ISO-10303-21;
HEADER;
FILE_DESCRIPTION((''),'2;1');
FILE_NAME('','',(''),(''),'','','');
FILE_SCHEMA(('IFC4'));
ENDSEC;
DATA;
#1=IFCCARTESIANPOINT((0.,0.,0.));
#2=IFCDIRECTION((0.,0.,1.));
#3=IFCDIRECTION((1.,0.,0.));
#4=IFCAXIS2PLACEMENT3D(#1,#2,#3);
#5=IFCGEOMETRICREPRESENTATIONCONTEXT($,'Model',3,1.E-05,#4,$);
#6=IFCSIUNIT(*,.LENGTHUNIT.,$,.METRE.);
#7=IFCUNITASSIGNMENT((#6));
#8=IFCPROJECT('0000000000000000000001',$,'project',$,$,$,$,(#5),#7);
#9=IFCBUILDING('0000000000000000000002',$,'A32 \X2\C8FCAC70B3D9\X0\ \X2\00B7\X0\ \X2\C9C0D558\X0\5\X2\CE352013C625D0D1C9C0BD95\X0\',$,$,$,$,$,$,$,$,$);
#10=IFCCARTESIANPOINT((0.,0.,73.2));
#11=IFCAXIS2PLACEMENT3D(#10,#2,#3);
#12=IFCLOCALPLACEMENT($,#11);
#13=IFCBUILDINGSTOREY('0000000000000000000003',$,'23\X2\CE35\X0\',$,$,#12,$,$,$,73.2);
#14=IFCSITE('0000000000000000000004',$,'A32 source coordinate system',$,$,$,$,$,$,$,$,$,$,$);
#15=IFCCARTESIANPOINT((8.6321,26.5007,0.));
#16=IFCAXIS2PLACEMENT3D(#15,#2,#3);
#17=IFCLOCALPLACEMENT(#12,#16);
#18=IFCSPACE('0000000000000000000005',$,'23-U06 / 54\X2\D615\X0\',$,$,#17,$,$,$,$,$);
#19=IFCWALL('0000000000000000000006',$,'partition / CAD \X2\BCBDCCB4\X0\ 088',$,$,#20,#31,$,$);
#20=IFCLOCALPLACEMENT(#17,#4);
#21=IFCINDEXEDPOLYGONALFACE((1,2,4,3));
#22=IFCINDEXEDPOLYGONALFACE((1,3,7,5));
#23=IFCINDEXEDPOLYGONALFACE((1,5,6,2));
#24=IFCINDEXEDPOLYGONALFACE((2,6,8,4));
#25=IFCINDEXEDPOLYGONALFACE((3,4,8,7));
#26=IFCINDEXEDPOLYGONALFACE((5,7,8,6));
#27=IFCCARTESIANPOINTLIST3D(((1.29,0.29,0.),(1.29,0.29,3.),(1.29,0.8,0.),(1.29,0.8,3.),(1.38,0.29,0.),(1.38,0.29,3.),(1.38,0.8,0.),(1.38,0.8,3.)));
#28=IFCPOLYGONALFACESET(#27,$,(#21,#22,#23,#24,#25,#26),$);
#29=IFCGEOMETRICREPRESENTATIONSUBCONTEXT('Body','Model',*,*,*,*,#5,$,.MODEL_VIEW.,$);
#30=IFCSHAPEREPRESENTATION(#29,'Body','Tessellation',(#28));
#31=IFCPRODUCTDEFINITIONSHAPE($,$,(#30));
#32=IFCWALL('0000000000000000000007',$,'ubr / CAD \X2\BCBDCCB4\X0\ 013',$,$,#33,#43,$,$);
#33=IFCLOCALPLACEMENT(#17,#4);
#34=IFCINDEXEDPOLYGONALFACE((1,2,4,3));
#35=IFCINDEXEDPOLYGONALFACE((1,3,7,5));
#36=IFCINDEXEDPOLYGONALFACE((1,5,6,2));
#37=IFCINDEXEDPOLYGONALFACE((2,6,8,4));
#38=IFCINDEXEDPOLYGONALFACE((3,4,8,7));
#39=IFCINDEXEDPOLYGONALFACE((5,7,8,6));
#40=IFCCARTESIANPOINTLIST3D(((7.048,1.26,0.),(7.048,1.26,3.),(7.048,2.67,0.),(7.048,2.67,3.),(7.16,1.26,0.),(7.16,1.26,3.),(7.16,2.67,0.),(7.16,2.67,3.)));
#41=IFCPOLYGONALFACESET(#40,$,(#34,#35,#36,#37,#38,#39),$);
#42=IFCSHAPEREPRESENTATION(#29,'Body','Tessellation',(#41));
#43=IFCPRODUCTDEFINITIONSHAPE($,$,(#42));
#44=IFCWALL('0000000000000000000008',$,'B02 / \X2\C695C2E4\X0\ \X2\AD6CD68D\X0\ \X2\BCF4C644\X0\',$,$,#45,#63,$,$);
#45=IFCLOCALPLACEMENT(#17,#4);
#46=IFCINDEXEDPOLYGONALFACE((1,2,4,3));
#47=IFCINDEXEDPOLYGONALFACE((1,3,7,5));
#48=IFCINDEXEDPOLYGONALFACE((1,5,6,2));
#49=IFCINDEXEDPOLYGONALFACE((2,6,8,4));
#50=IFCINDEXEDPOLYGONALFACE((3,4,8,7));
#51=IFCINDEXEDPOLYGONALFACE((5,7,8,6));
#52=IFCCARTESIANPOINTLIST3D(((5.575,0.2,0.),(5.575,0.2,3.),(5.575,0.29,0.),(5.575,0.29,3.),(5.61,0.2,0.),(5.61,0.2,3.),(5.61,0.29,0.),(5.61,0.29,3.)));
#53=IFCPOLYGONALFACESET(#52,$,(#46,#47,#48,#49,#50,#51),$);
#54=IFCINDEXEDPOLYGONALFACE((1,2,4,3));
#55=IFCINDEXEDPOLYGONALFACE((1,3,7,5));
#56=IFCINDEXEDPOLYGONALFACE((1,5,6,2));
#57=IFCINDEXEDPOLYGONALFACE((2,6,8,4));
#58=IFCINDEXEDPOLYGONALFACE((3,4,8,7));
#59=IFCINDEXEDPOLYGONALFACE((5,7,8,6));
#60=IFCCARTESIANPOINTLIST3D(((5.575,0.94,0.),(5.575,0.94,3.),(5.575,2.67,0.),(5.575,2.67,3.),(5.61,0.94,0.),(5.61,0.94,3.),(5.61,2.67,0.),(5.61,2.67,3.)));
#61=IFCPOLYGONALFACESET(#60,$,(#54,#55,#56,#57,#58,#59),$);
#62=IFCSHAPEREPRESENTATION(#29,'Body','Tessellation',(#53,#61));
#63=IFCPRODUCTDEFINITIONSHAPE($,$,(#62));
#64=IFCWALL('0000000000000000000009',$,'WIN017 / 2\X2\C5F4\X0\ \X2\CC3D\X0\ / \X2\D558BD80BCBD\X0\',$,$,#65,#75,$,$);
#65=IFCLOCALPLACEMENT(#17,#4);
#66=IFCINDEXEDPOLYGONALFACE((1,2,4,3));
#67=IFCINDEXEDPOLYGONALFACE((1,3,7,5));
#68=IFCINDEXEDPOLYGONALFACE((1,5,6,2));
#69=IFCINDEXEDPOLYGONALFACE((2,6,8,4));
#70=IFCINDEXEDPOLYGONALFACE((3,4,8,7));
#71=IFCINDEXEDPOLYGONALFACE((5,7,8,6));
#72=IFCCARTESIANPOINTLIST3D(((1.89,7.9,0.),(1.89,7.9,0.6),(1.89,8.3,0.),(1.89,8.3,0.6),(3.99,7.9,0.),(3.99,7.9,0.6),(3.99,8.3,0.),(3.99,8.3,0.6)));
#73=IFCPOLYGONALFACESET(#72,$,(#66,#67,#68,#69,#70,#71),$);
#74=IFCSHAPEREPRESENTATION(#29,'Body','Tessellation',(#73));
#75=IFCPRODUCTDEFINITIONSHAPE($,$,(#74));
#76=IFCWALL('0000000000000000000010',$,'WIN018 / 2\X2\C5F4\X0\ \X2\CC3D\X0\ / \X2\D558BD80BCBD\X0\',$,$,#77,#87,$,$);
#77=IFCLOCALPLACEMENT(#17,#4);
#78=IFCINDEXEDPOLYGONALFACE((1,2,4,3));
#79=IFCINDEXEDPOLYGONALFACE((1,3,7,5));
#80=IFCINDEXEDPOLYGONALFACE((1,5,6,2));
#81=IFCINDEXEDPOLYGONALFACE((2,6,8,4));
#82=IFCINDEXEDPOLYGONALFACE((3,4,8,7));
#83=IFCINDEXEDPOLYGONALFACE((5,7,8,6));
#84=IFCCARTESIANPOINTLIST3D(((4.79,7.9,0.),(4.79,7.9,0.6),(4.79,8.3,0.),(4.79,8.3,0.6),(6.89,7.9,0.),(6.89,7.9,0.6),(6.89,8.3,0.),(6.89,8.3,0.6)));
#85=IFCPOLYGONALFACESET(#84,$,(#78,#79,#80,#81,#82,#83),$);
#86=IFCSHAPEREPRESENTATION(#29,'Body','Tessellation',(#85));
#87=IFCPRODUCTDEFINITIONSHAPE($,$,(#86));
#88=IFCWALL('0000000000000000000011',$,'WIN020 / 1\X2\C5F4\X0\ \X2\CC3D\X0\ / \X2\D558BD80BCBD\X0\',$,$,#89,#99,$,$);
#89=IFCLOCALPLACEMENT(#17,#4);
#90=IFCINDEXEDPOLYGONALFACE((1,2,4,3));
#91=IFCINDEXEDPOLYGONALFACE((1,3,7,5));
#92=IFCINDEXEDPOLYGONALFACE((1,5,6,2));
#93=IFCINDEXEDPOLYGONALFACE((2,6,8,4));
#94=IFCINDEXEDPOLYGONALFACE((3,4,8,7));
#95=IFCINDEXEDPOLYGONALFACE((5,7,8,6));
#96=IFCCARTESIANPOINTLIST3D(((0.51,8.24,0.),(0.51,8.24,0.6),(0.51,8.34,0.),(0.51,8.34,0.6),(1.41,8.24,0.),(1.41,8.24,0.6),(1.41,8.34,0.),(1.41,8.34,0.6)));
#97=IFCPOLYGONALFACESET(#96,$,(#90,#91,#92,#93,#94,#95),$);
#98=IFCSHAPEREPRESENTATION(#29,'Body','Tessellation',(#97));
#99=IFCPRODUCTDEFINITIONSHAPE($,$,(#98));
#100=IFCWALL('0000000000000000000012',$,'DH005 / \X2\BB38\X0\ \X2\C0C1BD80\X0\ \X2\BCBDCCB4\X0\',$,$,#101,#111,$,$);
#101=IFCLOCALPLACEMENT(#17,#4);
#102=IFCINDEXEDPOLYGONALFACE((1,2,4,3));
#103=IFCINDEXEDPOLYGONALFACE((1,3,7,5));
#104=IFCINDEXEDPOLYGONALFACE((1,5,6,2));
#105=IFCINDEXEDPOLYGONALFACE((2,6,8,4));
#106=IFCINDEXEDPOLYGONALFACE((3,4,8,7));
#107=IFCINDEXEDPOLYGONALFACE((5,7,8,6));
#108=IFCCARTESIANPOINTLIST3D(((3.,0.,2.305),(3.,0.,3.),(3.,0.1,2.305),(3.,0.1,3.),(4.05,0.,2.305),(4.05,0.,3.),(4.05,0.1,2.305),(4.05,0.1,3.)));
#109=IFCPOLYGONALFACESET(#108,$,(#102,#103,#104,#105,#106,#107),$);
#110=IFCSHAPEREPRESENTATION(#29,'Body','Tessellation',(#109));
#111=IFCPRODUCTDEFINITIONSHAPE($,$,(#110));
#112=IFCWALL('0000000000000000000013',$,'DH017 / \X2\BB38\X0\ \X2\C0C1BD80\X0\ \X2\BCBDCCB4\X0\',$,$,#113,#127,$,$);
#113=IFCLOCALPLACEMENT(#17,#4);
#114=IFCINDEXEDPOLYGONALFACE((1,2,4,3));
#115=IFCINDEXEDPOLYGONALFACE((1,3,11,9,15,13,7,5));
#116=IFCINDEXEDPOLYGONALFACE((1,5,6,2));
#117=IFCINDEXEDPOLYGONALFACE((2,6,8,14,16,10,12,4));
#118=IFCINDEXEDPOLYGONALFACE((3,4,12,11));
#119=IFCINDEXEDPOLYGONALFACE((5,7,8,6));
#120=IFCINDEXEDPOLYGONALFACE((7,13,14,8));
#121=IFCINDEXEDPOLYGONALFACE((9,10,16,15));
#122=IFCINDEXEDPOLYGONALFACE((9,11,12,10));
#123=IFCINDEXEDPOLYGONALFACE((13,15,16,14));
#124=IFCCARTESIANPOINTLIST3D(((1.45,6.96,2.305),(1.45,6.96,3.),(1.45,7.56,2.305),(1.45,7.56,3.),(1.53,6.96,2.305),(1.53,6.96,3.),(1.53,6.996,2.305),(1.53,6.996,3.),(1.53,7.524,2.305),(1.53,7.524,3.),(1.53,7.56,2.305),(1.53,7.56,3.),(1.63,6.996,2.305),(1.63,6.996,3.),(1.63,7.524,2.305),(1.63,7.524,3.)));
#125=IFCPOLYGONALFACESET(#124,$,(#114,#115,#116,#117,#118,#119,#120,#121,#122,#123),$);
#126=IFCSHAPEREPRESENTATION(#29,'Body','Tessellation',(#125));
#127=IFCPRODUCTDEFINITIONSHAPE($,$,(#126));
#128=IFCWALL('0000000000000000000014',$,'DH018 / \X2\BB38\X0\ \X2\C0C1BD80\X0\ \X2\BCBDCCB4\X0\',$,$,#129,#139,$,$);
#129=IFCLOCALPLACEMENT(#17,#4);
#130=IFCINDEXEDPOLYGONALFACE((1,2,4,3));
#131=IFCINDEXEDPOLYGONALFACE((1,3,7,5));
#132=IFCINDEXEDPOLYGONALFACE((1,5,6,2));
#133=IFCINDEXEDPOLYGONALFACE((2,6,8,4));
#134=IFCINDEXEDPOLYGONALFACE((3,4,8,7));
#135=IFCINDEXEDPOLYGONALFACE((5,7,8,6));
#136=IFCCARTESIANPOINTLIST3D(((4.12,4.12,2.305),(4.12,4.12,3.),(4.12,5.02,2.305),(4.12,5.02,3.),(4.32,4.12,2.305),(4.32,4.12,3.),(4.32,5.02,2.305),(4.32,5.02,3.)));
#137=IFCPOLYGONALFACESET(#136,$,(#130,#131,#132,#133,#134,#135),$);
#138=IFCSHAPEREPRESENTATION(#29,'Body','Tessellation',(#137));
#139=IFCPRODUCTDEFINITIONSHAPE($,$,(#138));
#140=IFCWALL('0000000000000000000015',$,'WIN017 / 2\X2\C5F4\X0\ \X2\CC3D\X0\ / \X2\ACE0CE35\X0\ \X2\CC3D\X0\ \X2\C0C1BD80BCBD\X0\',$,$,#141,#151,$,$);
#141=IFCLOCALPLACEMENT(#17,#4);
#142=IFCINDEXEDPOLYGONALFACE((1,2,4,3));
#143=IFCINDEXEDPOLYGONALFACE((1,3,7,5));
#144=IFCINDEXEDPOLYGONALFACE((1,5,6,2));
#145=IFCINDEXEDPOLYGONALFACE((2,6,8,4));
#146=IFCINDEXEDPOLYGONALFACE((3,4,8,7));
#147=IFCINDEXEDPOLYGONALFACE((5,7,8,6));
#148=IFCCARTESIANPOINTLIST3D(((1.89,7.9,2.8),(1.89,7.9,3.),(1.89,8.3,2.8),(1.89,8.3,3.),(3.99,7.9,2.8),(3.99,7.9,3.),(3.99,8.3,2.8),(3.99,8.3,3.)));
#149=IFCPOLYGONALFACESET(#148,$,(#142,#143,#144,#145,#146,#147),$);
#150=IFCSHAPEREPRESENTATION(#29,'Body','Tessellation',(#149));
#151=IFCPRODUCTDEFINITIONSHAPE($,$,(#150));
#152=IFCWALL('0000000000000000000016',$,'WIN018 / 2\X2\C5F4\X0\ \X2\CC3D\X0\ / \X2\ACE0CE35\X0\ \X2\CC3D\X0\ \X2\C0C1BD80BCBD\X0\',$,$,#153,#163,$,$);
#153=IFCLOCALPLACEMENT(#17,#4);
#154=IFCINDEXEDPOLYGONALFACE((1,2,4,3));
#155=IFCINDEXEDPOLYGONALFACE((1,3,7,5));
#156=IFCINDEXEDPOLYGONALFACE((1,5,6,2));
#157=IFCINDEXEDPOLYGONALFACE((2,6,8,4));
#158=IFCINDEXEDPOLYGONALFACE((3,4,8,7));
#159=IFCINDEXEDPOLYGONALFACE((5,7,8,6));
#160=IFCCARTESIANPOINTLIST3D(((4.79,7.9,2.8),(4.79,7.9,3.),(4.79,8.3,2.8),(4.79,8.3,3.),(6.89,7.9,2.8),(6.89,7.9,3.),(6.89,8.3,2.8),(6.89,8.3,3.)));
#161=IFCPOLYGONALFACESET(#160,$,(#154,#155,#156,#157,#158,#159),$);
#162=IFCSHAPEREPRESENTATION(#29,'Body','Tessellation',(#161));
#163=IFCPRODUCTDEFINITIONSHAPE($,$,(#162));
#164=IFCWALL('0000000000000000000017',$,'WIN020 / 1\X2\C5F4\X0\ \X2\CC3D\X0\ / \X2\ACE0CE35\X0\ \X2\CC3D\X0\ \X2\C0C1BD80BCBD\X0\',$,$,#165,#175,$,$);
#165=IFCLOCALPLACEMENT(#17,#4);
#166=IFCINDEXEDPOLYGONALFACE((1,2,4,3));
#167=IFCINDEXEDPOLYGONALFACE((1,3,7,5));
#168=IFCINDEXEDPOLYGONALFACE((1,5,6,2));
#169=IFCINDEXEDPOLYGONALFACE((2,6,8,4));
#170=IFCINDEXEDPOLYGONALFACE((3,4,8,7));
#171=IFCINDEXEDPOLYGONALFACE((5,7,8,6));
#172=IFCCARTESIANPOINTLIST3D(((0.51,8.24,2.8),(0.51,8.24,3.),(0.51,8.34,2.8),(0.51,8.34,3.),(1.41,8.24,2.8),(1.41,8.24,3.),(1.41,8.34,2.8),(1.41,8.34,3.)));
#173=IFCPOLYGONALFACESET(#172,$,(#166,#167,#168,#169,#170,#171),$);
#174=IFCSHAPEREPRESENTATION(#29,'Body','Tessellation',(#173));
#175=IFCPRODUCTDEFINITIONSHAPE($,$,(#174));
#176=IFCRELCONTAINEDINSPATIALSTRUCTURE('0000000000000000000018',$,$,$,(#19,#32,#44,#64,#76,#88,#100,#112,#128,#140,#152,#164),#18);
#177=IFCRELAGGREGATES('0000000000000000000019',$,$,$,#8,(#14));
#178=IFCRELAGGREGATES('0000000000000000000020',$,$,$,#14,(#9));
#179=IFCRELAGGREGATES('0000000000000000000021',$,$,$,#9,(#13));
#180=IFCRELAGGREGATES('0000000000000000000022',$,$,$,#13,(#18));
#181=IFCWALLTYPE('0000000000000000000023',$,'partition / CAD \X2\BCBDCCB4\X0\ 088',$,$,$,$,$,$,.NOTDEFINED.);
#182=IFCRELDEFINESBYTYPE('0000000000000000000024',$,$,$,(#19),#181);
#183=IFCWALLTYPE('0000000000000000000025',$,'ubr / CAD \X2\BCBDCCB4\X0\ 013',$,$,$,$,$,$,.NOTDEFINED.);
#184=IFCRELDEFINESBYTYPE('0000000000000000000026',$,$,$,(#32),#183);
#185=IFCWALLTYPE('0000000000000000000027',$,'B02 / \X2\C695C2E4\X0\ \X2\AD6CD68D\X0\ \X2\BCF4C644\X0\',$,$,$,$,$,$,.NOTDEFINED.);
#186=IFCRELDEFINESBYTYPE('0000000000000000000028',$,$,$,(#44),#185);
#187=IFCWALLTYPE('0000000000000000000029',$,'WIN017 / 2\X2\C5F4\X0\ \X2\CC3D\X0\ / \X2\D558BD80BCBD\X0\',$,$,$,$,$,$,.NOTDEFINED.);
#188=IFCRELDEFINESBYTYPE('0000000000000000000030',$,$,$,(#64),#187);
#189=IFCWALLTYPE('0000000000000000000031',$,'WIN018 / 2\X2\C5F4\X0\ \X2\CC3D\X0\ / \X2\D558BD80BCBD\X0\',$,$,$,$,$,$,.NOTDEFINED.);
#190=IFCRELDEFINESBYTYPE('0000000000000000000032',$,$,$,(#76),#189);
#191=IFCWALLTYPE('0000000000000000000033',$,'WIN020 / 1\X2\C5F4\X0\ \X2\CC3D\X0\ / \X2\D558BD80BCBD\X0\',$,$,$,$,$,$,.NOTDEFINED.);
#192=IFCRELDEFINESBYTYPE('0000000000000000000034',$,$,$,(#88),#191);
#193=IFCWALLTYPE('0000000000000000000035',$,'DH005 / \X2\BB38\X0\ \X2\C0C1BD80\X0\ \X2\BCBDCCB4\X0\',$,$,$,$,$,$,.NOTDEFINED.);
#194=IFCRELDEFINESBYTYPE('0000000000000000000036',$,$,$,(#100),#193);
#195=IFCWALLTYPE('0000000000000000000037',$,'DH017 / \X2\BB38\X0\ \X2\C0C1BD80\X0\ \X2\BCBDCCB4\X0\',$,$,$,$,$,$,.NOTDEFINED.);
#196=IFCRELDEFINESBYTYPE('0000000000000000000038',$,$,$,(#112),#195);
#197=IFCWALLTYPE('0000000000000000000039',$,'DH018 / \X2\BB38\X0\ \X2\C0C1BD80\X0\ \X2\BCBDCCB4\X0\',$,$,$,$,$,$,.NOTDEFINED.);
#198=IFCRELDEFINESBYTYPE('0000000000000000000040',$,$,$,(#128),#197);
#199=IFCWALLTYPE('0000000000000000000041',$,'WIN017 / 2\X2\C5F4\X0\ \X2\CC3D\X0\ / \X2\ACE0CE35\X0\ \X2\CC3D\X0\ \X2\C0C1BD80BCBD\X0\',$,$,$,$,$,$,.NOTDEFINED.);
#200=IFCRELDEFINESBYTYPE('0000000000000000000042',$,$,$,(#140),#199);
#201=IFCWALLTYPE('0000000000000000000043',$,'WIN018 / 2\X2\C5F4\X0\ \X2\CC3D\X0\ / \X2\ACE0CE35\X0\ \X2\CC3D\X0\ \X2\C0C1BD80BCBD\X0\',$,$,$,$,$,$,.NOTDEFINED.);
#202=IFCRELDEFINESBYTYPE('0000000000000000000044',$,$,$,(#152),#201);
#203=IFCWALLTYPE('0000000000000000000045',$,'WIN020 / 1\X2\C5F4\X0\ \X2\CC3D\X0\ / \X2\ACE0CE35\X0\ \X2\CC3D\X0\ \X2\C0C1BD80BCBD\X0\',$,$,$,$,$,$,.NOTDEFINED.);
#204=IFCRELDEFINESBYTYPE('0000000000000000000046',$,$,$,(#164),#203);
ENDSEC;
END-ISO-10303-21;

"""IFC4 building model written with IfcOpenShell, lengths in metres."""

from ifc_helpers import new_model, si_unit, frame, origin, origin_with_axes, place, context, subcontext, project, spatial, polyline, outline, extrude, source, transform, mapped, type_object, type_shapes, element, save


model = new_model("IFC4")

# Units and contexts
model_context = context("Model", 3, precision=1e-05, world=origin_with_axes())
body_context = subcontext(model_context, "Body", "Model", "MODEL_VIEW")
ifc_project = project(units=[si_unit("LENGTHUNIT", "METRE")], contexts=[model_context])

# Site, building, storey, space
site = spatial("IfcSite", under=ifc_project, Name="A32 source coordinate system")
building = spatial("IfcBuilding", under=site, Name="A32 주거동 · 지하5층–옥탑지붕")
storey_placement = place(None, frame((0.0, 0.0, 73.2), z_axis=(0.0, 0.0, 1.0), x_axis=(1.0, 0.0, 0.0)))
storey = spatial("IfcBuildingStorey", under=building, at=storey_placement, Name="23층", Elevation=73.2)
space_placement = place(storey_placement, frame((8.6321, 26.5007, 0.0), z_axis=(0.0, 0.0, 1.0), x_axis=(1.0, 0.0, 0.0)))
space = spatial("IfcSpace", under=storey, at=space_placement, Name="23-U06 / 54형")

# Walls
wall_type_1 = type_object("IfcWallType", Name="partition / CAD 벽체 088", PredefinedType="NOTDEFINED")
shared_shape_1 = source(origin(), body_context, "Body", "SweptSolid", [
    extrude(outline(polyline([(1.29, 0.29), (1.29, 0.8), (1.38, 0.8), (1.38, 0.29), (1.29, 0.29)])), origin(), (0.0, 0.0, 1.0), 3.0),
])
type_shapes(wall_type_1, [shared_shape_1])
wall_1_placement = place(space_placement, origin_with_axes())
element("IfcWall", 1, at=wall_1_placement, inside=space, type_object=wall_type_1, Name="partition / CAD 벽체 088", context=body_context, shape_type="MappedRepresentation", body=[
    mapped(shared_shape_1, transform((0.0, 0.0, 0.0), scale=1.0)),
])
wall_type_2 = type_object("IfcWallType", Name="ubr / CAD 벽체 013", PredefinedType="NOTDEFINED")
shared_shape_2 = source(origin(), body_context, "Body", "SweptSolid", [
    extrude(outline(polyline([(7.16, 1.26), (7.048, 1.26), (7.048, 2.67), (7.16, 2.67), (7.16, 1.26)])), origin(), (0.0, 0.0, 1.0), 3.0),
])
type_shapes(wall_type_2, [shared_shape_2])
wall_2_placement = place(space_placement, origin_with_axes())
element("IfcWall", 2, at=wall_2_placement, inside=space, type_object=wall_type_2, Name="ubr / CAD 벽체 013", context=body_context, shape_type="MappedRepresentation", body=[
    mapped(shared_shape_2, transform((0.0, 0.0, 0.0), scale=1.0)),
])
wall_type_3 = type_object("IfcWallType", Name="B02 / 욕실 구획 보완", PredefinedType="NOTDEFINED")
shared_shape_3 = source(origin(), body_context, "Body", "SweptSolid", [
    extrude(outline(polyline([(5.575, 0.2), (5.575, 0.29), (5.61, 0.29), (5.61, 0.2), (5.575, 0.2)])), origin(), (0.0, 0.0, 1.0), 3.0),
    extrude(outline(polyline([(5.575, 0.94), (5.575, 2.67), (5.61, 2.67), (5.61, 0.94), (5.575, 0.94)])), origin(), (0.0, 0.0, 1.0), 3.0),
])
type_shapes(wall_type_3, [shared_shape_3])
wall_3_placement = place(space_placement, origin_with_axes())
element("IfcWall", 3, at=wall_3_placement, inside=space, type_object=wall_type_3, Name="B02 / 욕실 구획 보완", context=body_context, shape_type="MappedRepresentation", body=[
    mapped(shared_shape_3, transform((0.0, 0.0, 0.0), scale=1.0)),
])
wall_type_4 = type_object("IfcWallType", Name="WIN017 / 2열 창 / 하부벽", PredefinedType="NOTDEFINED")
shared_shape_4 = source(origin(), body_context, "Body", "SweptSolid", [
    extrude(outline(polyline([(3.99, 8.3), (3.99, 7.9), (1.89, 7.9), (1.89, 8.3), (3.99, 8.3)])), origin(), (0.0, 0.0, 1.0), 0.6),
])
type_shapes(wall_type_4, [shared_shape_4])
wall_4_placement = place(space_placement, origin_with_axes())
element("IfcWall", 4, at=wall_4_placement, inside=space, type_object=wall_type_4, Name="WIN017 / 2열 창 / 하부벽", context=body_context, shape_type="MappedRepresentation", body=[
    mapped(shared_shape_4, transform((0.0, 0.0, 0.0), scale=1.0)),
])
wall_type_5 = type_object("IfcWallType", Name="WIN018 / 2열 창 / 하부벽", PredefinedType="NOTDEFINED")
shared_shape_5 = source(origin(), body_context, "Body", "SweptSolid", [
    extrude(outline(polyline([(6.89, 8.3), (6.89, 7.9), (4.79, 7.9), (4.79, 8.3), (6.89, 8.3)])), origin(), (0.0, 0.0, 1.0), 0.6),
])
type_shapes(wall_type_5, [shared_shape_5])
wall_5_placement = place(space_placement, origin_with_axes())
element("IfcWall", 5, at=wall_5_placement, inside=space, type_object=wall_type_5, Name="WIN018 / 2열 창 / 하부벽", context=body_context, shape_type="MappedRepresentation", body=[
    mapped(shared_shape_5, transform((0.0, 0.0, 0.0), scale=1.0)),
])
wall_type_6 = type_object("IfcWallType", Name="WIN020 / 1열 창 / 하부벽", PredefinedType="NOTDEFINED")
shared_shape_6 = source(origin(), body_context, "Body", "SweptSolid", [
    extrude(outline(polyline([(1.41, 8.34), (1.41, 8.24), (0.51, 8.24), (0.51, 8.34), (1.41, 8.34)])), origin(), (0.0, 0.0, 1.0), 0.6),
])
type_shapes(wall_type_6, [shared_shape_6])
wall_6_placement = place(space_placement, origin_with_axes())
element("IfcWall", 6, at=wall_6_placement, inside=space, type_object=wall_type_6, Name="WIN020 / 1열 창 / 하부벽", context=body_context, shape_type="MappedRepresentation", body=[
    mapped(shared_shape_6, transform((0.0, 0.0, 0.0), scale=1.0)),
])
wall_type_7 = type_object("IfcWallType", Name="DH005 / 문 상부 벽체", PredefinedType="NOTDEFINED")
shared_shape_7 = source(origin(), body_context, "Body", "SweptSolid", [
    extrude(outline(polyline([(4.05, 0.0), (3.0, 0.0), (3.0, 0.1), (4.05, 0.1), (4.05, 0.0)])), frame((0.0, 0.0, 2.305)), (0.0, 0.0, 1.0), 0.695),
])
type_shapes(wall_type_7, [shared_shape_7])
wall_7_placement = place(space_placement, origin_with_axes())
element("IfcWall", 7, at=wall_7_placement, inside=space, type_object=wall_type_7, Name="DH005 / 문 상부 벽체", context=body_context, shape_type="MappedRepresentation", body=[
    mapped(shared_shape_7, transform((0.0, 0.0, 0.0), scale=1.0)),
])
wall_type_8 = type_object("IfcWallType", Name="DH017 / 문 상부 벽체", PredefinedType="NOTDEFINED")
shared_shape_8 = source(origin(), body_context, "Body", "SweptSolid", [
    extrude(outline(polyline([(1.63, 7.524), (1.63, 6.996), (1.53, 6.996), (1.53, 6.96), (1.45, 6.96), (1.45, 7.56), (1.53, 7.56), (1.53, 7.524), (1.63, 7.524)])), frame((0.0, 0.0, 2.305)), (0.0, 0.0, 1.0), 0.695),
])
type_shapes(wall_type_8, [shared_shape_8])
wall_8_placement = place(space_placement, origin_with_axes())
element("IfcWall", 8, at=wall_8_placement, inside=space, type_object=wall_type_8, Name="DH017 / 문 상부 벽체", context=body_context, shape_type="MappedRepresentation", body=[
    mapped(shared_shape_8, transform((0.0, 0.0, 0.0), scale=1.0)),
])
wall_type_9 = type_object("IfcWallType", Name="DH018 / 문 상부 벽체", PredefinedType="NOTDEFINED")
shared_shape_9 = source(origin(), body_context, "Body", "SweptSolid", [
    extrude(outline(polyline([(4.32, 4.12), (4.12, 4.12), (4.12, 5.02), (4.32, 5.02), (4.32, 4.12)])), frame((0.0, 0.0, 2.305)), (0.0, 0.0, 1.0), 0.695),
])
type_shapes(wall_type_9, [shared_shape_9])
wall_9_placement = place(space_placement, origin_with_axes())
element("IfcWall", 9, at=wall_9_placement, inside=space, type_object=wall_type_9, Name="DH018 / 문 상부 벽체", context=body_context, shape_type="MappedRepresentation", body=[
    mapped(shared_shape_9, transform((0.0, 0.0, 0.0), scale=1.0)),
])
wall_type_10 = type_object("IfcWallType", Name="WIN017 / 2열 창 / 고층 창 상부벽", PredefinedType="NOTDEFINED")
shared_shape_10 = source(origin(), body_context, "Body", "SweptSolid", [
    extrude(outline(polyline([(3.99, 7.9), (3.99, 8.3), (1.89, 8.3), (1.89, 7.9), (3.99, 7.9)])), frame((0.0, 0.0, 2.8)), (0.0, 0.0, 1.0), 0.2),
])
type_shapes(wall_type_10, [shared_shape_10])
wall_10_placement = place(space_placement, origin_with_axes())
element("IfcWall", 10, at=wall_10_placement, inside=space, type_object=wall_type_10, Name="WIN017 / 2열 창 / 고층 창 상부벽", context=body_context, shape_type="MappedRepresentation", body=[
    mapped(shared_shape_10, transform((0.0, 0.0, 0.0), scale=1.0)),
])
wall_type_11 = type_object("IfcWallType", Name="WIN018 / 2열 창 / 고층 창 상부벽", PredefinedType="NOTDEFINED")
shared_shape_11 = source(origin(), body_context, "Body", "SweptSolid", [
    extrude(outline(polyline([(6.89, 7.9), (6.89, 8.3), (4.79, 8.3), (4.79, 7.9), (6.89, 7.9)])), frame((0.0, 0.0, 2.8)), (0.0, 0.0, 1.0), 0.2),
])
type_shapes(wall_type_11, [shared_shape_11])
wall_11_placement = place(space_placement, origin_with_axes())
element("IfcWall", 11, at=wall_11_placement, inside=space, type_object=wall_type_11, Name="WIN018 / 2열 창 / 고층 창 상부벽", context=body_context, shape_type="MappedRepresentation", body=[
    mapped(shared_shape_11, transform((0.0, 0.0, 0.0), scale=1.0)),
])
wall_type_12 = type_object("IfcWallType", Name="WIN020 / 1열 창 / 고층 창 상부벽", PredefinedType="NOTDEFINED")
shared_shape_12 = source(origin(), body_context, "Body", "SweptSolid", [
    extrude(outline(polyline([(1.41, 8.24), (1.41, 8.34), (0.51, 8.34), (0.51, 8.24), (1.41, 8.24)])), frame((0.0, 0.0, 2.8)), (0.0, 0.0, 1.0), 0.2),
])
type_shapes(wall_type_12, [shared_shape_12])
wall_12_placement = place(space_placement, origin_with_axes())
element("IfcWall", 12, at=wall_12_placement, inside=space, type_object=wall_type_12, Name="WIN020 / 1열 창 / 고층 창 상부벽", context=body_context, shape_type="MappedRepresentation", body=[
    mapped(shared_shape_12, transform((0.0, 0.0, 0.0), scale=1.0)),
])

save(model, "model.ifc")
